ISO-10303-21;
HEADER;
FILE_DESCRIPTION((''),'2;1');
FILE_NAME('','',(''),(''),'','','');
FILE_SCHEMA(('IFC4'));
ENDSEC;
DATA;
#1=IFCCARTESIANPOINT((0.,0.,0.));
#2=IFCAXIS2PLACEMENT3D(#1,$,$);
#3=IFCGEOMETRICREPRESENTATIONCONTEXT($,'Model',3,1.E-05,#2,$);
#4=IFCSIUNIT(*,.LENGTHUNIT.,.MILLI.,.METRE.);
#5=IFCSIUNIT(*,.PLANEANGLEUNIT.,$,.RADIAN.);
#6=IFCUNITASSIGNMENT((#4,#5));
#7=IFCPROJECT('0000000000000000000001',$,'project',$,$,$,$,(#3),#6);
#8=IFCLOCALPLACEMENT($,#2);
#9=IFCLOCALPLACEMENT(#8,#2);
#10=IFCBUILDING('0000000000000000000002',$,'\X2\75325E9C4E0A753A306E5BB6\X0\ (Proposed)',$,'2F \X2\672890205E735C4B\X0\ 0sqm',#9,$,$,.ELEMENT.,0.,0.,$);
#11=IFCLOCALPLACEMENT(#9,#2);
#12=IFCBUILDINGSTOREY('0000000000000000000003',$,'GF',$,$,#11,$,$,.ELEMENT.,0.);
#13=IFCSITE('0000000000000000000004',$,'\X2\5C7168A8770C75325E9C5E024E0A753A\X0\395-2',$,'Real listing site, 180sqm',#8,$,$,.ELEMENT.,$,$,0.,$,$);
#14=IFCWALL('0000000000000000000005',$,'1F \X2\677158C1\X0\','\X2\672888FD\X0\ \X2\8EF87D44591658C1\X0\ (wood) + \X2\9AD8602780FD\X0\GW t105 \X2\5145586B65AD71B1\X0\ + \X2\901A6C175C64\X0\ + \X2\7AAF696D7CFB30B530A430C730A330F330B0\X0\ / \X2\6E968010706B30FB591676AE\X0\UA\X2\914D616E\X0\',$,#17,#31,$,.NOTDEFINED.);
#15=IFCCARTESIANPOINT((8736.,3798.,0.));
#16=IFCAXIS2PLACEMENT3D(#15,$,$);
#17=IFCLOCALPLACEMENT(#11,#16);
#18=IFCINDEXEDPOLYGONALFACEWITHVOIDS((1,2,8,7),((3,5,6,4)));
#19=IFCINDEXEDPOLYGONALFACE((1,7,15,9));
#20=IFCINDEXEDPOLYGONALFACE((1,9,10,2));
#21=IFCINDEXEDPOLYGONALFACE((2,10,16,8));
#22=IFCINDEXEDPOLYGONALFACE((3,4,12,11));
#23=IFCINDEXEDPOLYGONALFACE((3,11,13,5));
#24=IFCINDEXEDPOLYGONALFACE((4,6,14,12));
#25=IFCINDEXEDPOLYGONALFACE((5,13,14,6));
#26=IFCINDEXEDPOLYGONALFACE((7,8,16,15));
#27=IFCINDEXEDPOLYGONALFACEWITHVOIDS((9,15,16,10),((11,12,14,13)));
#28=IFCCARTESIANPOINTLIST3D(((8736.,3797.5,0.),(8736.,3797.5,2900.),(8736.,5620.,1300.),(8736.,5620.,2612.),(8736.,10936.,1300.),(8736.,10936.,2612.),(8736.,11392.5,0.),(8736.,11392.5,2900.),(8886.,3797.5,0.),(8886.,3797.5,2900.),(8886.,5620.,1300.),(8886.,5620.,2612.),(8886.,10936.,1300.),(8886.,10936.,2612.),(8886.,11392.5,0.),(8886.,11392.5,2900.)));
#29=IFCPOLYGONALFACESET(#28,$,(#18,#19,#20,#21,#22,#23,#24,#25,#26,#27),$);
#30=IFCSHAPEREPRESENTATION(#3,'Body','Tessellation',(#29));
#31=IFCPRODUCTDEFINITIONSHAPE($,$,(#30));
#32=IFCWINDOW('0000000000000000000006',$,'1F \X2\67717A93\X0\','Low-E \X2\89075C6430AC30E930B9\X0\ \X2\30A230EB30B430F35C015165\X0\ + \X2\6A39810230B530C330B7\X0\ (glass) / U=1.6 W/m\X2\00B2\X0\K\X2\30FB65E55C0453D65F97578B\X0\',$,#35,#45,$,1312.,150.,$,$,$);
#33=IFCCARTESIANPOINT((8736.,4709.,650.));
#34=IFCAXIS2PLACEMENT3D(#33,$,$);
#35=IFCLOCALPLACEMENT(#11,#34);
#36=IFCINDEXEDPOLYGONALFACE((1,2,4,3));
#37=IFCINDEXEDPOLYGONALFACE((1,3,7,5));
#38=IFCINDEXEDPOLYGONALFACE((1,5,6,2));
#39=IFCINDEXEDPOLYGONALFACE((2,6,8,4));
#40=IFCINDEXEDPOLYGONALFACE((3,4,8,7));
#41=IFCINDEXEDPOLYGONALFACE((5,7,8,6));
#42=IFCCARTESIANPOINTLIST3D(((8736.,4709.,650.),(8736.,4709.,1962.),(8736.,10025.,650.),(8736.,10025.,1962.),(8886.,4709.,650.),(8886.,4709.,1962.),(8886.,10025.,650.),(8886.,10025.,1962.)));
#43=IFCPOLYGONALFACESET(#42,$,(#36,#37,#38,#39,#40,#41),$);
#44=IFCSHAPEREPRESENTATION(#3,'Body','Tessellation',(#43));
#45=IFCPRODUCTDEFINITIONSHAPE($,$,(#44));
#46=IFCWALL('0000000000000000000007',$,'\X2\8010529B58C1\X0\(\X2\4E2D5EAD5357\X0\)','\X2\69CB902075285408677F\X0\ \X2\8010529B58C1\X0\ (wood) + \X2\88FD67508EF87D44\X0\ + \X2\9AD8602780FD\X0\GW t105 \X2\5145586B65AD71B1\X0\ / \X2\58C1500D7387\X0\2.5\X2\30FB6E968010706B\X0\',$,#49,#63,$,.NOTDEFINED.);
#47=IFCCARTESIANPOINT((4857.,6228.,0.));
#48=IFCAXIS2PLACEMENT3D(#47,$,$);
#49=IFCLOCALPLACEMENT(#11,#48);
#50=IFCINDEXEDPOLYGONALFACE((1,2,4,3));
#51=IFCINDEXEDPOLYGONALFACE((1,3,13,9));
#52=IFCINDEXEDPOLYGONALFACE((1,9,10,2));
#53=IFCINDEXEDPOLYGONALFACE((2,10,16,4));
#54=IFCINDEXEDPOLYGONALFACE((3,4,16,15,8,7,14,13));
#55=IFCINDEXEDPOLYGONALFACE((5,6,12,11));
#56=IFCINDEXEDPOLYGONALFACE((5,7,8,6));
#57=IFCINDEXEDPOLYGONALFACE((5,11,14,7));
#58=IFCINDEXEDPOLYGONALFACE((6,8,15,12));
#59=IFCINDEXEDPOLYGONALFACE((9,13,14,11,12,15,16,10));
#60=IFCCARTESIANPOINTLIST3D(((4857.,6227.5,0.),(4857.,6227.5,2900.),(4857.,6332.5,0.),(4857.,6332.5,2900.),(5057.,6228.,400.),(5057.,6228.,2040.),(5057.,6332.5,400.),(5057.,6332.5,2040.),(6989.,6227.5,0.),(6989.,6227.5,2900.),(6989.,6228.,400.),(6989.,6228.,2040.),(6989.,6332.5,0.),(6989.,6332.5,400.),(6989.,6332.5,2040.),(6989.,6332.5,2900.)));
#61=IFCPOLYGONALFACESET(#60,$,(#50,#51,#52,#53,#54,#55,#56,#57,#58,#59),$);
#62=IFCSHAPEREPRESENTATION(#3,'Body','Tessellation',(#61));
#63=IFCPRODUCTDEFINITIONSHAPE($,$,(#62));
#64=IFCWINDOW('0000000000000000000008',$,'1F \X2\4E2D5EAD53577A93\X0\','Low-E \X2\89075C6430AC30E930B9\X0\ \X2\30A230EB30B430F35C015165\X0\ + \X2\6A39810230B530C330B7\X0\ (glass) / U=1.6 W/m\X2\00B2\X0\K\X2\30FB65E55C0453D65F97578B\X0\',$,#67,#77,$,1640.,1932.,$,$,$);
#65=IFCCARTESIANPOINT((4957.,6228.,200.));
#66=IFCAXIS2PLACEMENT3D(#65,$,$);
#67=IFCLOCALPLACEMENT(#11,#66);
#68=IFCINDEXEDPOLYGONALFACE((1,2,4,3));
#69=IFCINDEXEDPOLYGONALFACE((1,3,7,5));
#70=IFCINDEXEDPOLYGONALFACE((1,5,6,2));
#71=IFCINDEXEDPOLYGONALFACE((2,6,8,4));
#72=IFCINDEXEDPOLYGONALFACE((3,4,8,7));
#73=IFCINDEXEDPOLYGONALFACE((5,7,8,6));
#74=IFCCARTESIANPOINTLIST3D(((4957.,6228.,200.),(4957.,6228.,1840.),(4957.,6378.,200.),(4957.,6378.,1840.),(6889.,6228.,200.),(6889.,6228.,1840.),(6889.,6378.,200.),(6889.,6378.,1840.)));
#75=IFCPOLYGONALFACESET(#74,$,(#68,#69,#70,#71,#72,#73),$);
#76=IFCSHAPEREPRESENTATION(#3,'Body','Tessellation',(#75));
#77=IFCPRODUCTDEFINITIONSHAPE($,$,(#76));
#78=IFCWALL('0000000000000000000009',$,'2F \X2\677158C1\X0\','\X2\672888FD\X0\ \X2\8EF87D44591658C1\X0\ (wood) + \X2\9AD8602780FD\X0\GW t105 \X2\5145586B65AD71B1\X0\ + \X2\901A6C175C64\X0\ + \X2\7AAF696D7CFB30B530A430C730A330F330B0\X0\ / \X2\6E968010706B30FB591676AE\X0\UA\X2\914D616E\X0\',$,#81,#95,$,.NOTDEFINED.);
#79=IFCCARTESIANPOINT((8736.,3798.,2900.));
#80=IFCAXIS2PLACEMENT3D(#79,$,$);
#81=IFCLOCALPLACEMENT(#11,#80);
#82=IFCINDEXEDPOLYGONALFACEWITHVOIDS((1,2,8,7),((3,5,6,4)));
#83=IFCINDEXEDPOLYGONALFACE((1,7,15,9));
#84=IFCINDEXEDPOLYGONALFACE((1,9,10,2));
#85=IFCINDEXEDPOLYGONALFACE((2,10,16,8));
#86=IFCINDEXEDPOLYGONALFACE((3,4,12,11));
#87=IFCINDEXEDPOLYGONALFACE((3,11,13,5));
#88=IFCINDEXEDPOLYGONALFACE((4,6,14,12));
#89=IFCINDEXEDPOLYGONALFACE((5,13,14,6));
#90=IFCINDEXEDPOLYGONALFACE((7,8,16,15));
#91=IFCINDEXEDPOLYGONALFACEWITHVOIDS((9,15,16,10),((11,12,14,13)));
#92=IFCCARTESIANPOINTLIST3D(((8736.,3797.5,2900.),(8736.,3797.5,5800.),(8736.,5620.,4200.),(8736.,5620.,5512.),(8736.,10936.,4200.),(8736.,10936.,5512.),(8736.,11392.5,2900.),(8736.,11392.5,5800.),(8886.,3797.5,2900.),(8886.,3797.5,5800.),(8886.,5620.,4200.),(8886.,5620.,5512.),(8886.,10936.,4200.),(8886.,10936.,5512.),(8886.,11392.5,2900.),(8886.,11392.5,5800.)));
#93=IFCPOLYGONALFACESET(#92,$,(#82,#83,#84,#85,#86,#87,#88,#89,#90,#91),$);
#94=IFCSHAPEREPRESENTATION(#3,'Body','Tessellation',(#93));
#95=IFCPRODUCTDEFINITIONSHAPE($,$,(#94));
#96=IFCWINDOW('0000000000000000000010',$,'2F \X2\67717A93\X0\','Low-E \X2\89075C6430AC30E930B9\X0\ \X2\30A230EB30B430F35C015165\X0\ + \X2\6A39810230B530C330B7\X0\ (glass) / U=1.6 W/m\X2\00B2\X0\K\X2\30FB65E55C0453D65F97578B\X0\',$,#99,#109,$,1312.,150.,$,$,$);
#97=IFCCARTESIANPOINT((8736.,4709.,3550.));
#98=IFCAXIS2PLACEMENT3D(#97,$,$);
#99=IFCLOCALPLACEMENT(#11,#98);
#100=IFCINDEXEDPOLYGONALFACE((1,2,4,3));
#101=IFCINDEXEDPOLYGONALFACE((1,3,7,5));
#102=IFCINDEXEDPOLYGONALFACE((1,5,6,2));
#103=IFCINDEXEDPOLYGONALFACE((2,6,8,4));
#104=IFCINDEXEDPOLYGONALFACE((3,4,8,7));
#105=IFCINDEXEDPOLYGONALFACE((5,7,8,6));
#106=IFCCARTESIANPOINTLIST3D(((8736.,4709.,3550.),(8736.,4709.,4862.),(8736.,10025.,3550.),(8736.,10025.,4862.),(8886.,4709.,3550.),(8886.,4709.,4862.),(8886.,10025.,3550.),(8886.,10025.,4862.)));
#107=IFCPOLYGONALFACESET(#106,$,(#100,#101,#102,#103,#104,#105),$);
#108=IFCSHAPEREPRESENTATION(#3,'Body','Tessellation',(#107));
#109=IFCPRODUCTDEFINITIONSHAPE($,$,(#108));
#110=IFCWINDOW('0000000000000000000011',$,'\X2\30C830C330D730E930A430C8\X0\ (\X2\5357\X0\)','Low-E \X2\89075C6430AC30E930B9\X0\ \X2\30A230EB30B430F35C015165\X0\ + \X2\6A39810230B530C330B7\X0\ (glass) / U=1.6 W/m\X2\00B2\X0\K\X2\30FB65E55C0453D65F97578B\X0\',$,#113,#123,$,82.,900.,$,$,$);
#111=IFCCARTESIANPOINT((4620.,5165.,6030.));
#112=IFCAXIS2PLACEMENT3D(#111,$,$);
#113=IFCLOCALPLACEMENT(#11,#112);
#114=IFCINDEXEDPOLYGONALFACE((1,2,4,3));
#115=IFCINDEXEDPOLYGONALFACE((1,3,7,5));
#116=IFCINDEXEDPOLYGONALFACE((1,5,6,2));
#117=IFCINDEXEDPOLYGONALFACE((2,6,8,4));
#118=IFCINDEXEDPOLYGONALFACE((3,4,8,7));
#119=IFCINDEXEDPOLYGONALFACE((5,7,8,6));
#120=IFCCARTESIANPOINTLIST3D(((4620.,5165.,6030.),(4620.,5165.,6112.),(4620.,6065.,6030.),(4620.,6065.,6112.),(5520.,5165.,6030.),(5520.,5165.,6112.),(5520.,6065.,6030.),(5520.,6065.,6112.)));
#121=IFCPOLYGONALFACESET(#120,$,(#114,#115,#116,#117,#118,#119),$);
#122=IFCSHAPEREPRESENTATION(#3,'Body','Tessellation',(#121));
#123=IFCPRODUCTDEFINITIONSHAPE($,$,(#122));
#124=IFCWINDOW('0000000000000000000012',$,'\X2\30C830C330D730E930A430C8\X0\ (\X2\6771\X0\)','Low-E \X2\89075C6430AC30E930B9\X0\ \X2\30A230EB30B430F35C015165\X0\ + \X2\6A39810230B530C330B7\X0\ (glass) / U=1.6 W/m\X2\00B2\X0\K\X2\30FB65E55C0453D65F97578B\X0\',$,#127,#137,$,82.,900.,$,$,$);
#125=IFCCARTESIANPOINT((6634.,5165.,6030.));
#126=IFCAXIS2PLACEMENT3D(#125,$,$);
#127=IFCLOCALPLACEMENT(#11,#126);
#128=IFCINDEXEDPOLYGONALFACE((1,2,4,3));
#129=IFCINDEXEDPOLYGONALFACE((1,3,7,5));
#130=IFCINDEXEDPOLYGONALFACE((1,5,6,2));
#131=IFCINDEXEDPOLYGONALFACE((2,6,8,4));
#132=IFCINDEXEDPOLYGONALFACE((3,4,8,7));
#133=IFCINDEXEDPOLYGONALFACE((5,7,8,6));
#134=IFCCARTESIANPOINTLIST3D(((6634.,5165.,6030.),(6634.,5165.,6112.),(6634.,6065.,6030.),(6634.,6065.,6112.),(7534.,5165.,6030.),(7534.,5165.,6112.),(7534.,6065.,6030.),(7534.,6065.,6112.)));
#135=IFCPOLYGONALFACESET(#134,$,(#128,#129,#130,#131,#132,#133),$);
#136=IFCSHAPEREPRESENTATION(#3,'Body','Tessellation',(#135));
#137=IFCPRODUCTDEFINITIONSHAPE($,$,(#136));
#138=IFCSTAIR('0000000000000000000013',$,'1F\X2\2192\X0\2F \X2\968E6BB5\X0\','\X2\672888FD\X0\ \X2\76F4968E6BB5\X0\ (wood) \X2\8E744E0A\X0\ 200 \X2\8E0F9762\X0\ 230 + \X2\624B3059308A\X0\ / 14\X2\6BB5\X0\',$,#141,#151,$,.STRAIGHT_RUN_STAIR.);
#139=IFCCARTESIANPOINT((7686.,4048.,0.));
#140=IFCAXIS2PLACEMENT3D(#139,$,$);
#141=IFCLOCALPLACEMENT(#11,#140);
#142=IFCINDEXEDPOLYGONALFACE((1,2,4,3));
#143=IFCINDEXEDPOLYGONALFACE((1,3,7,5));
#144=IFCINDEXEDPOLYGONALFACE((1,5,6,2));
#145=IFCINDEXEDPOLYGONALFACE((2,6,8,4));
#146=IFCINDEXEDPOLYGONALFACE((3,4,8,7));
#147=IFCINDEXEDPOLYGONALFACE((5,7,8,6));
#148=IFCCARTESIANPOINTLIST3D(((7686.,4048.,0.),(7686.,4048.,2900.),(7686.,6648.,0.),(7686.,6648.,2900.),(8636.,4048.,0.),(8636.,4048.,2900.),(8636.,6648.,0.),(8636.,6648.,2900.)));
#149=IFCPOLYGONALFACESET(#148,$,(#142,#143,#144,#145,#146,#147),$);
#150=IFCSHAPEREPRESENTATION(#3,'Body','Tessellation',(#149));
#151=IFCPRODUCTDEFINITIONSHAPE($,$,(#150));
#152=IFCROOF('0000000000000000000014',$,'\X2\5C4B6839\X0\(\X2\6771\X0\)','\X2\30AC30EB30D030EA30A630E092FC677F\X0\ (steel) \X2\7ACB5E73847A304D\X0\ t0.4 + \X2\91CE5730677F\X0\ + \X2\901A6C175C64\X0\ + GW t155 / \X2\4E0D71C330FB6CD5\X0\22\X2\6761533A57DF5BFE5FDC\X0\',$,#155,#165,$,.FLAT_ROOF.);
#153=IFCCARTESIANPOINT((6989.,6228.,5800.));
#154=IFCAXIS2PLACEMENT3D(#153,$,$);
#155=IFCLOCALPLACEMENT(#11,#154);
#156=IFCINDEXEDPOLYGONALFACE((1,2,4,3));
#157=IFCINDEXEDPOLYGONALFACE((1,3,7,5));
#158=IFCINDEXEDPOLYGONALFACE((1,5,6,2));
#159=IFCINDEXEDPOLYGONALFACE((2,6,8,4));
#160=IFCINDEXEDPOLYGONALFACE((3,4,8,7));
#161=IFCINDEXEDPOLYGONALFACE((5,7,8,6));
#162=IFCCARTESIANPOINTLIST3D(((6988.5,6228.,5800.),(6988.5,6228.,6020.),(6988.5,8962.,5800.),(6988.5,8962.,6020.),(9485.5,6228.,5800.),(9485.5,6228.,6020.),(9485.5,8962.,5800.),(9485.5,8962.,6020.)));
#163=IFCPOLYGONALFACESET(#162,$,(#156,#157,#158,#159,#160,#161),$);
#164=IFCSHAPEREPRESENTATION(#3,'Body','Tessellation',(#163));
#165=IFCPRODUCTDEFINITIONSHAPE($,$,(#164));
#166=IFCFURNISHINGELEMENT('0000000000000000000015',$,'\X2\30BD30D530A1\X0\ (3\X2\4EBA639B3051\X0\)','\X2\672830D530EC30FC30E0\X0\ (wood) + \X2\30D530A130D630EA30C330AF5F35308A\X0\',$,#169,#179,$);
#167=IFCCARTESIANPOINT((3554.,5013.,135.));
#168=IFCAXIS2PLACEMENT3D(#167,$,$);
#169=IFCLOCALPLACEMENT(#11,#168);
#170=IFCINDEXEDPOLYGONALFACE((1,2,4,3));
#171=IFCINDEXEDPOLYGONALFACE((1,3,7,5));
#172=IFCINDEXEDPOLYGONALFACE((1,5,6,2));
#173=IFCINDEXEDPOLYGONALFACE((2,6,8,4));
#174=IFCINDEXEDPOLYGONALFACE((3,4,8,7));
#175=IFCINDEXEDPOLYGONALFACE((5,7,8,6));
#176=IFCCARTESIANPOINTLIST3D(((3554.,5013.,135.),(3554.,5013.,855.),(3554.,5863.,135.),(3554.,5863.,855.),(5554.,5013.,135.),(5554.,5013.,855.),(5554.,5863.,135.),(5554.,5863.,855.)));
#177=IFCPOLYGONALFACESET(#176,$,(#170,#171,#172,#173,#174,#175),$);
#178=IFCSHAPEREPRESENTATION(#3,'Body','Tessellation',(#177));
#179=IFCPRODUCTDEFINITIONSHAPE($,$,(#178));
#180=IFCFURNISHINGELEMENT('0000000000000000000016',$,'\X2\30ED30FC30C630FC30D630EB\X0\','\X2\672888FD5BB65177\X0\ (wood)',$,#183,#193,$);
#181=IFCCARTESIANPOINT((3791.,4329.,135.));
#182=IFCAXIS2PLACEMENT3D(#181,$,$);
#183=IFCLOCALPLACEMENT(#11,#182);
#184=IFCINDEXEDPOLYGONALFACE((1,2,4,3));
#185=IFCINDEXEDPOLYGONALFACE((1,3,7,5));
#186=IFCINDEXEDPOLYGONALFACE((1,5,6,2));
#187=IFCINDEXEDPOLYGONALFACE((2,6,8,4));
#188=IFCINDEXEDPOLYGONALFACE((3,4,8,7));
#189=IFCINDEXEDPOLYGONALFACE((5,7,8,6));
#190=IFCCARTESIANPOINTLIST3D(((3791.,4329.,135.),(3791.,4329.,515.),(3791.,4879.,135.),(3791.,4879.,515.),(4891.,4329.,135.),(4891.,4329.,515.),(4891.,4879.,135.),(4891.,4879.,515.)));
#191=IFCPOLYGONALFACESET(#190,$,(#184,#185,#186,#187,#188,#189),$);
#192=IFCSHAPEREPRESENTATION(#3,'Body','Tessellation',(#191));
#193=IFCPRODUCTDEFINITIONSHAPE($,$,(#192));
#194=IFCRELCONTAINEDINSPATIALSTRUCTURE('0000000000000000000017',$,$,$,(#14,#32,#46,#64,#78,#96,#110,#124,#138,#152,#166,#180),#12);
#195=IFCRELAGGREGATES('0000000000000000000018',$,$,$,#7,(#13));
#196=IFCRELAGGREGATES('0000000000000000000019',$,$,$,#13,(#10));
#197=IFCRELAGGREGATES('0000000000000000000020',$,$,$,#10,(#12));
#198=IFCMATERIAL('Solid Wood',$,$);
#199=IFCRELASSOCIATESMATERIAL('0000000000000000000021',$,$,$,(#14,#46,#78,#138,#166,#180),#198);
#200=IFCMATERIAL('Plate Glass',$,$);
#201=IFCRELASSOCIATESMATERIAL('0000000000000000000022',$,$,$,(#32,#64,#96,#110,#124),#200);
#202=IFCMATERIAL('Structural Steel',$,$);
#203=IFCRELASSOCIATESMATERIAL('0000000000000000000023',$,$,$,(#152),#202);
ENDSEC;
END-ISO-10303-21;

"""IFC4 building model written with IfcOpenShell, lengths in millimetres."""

from ifc_helpers import new_model, si_unit, frame, frame_2d, origin, place, context, project, spatial, rectangle, extrude, material, element, fill, save


model = new_model("IFC4")

# Units and contexts
model_context = context("Model", 3, precision=1e-05, world=origin())
ifc_project = project(units=[si_unit("LENGTHUNIT", "METRE", prefix="MILLI"), si_unit("PLANEANGLEUNIT", "RADIAN")], contexts=[model_context])

# Site, building, storey
site_placement = place(None, origin())
site = spatial("IfcSite", under=ifc_project, at=site_placement, Name="山梨県甲府市上町395-2", ObjectType="Real listing site, 180sqm", CompositionType="ELEMENT", RefElevation=0.0)
building_placement = place(site_placement, origin())
building = spatial("IfcBuilding", under=site, at=building_placement, Name="甲府上町の家 (Proposed)", ObjectType="2F 木造平屋 0sqm", CompositionType="ELEMENT", ElevationOfRefHeight=0.0, ElevationOfTerrain=0.0)
storey_placement = place(building_placement, origin())
storey = spatial("IfcBuildingStorey", under=building, at=storey_placement, Name="GF", CompositionType="ELEMENT", Elevation=0.0)

# Shared definitions
ifc_material_1 = material(Name="Solid Wood")

# Walls, openings, windows
wall_1_placement = place(storey_placement, frame((8736.0, 3798.0, 0.0)))
wall_1 = element("IfcWall", 1, at=wall_1_placement, inside=storey, material=ifc_material_1, Name="1F 東壁", Description="木製 軸組外壁 (wood) + 高性能GW t105 充填断熱 + 通気層 + 窯業系サイディング / 準耐火・外皮UA配慮", PredefinedType="NOTDEFINED", context=model_context, shape_type="SweptSolid", body=[
    extrude(rectangle(XDim=150.0, YDim=7595.0, at=frame_2d((75.0, 3797.0))), frame((8736.0, 3798.0, 0.0)), (0.0, 0.0, 1.0), 2900.0),
])
opening_1_placement = place(storey_placement, frame((8736.0, 4709.0, 650.0)))
opening_1 = element("IfcOpeningElement", 2, at=opening_1_placement, cuts=wall_1, PredefinedType="NOTDEFINED", context=model_context, shape_type="SweptSolid", body=[
    extrude(rectangle(XDim=150.0, YDim=5316.0, at=frame_2d((75.0, 2658.0))), frame((8736.0, 4709.0, 650.0)), (0.0, 0.0, 1.0), 1312.0),
])
ifc_material_2 = material(Name="Plate Glass")
window_1_placement = place(storey_placement, frame((8736.0, 4709.0, 650.0)))
window_1 = element("IfcWindow", 3, at=window_1_placement, inside=storey, material=ifc_material_2, Name="1F 東窓", Description="Low-E 複層ガラス アルゴン封入 + 樹脂サッシ (glass) / U=1.6 W/m²K・日射取得型", OverallHeight=1312.0, OverallWidth=150.0, context=model_context, shape_type="SweptSolid", body=[
    extrude(rectangle(XDim=150.0, YDim=5316.0, at=frame_2d((75.0, 2658.0))), frame((8736.0, 4709.0, 650.0)), (0.0, 0.0, 1.0), 1312.0),
])
fill(opening_1, window_1)
wall_2_placement = place(storey_placement, frame((4857.0, 6228.0, 0.0)))
wall_2 = element("IfcWall", 4, at=wall_2_placement, inside=storey, material=ifc_material_1, Name="耐力壁(中庭南)", Description="構造用合板 耐力壁 (wood) + 製材軸組 + 高性能GW t105 充填断熱 / 壁倍率2.5・準耐火", PredefinedType="NOTDEFINED", context=model_context, shape_type="SweptSolid", body=[
    extrude(rectangle(XDim=2132.0, YDim=105.0, at=frame_2d((1066.0, 52.0))), frame((4857.0, 6228.0, 0.0)), (0.0, 0.0, 1.0), 2900.0),
])
opening_2_placement = place(storey_placement, frame((4957.0, 6228.0, 200.0)))
opening_2 = element("IfcOpeningElement", 5, at=opening_2_placement, cuts=wall_2, PredefinedType="NOTDEFINED", context=model_context, shape_type="SweptSolid", body=[
    extrude(rectangle(XDim=1932.0, YDim=150.0, at=frame_2d((966.0, 75.0))), frame((4957.0, 6228.0, 200.0)), (0.0, 0.0, 1.0), 1640.0),
])
window_2_placement = place(storey_placement, frame((4957.0, 6228.0, 200.0)))
window_2 = element("IfcWindow", 6, at=window_2_placement, inside=storey, material=ifc_material_2, Name="1F 中庭南窓", Description="Low-E 複層ガラス アルゴン封入 + 樹脂サッシ (glass) / U=1.6 W/m²K・日射取得型", OverallHeight=1640.0, OverallWidth=1932.0, context=model_context, shape_type="SweptSolid", body=[
    extrude(rectangle(XDim=1932.0, YDim=150.0, at=frame_2d((966.0, 75.0))), frame((4957.0, 6228.0, 200.0)), (0.0, 0.0, 1.0), 1640.0),
])
fill(opening_2, window_2)

# Wall, opening, window
wall_3_placement = place(storey_placement, frame((8736.0, 3798.0, 2900.0)))
wall_3 = element("IfcWall", 7, at=wall_3_placement, inside=storey, material=ifc_material_1, Name="2F 東壁", Description="木製 軸組外壁 (wood) + 高性能GW t105 充填断熱 + 通気層 + 窯業系サイディング / 準耐火・外皮UA配慮", PredefinedType="NOTDEFINED", context=model_context, shape_type="SweptSolid", body=[
    extrude(rectangle(XDim=150.0, YDim=7595.0, at=frame_2d((75.0, 3797.0))), frame((8736.0, 3798.0, 2900.0)), (0.0, 0.0, 1.0), 2900.0),
])
opening_3_placement = place(storey_placement, frame((8736.0, 4709.0, 3550.0)))
opening_3 = element("IfcOpeningElement", 8, at=opening_3_placement, cuts=wall_3, PredefinedType="NOTDEFINED", context=model_context, shape_type="SweptSolid", body=[
    extrude(rectangle(XDim=150.0, YDim=5316.0, at=frame_2d((75.0, 2658.0))), frame((8736.0, 4709.0, 3550.0)), (0.0, 0.0, 1.0), 1312.0),
])
window_3_placement = place(storey_placement, frame((8736.0, 4709.0, 3550.0)))
window_3 = element("IfcWindow", 9, at=window_3_placement, inside=storey, material=ifc_material_2, Name="2F 東窓", Description="Low-E 複層ガラス アルゴン封入 + 樹脂サッシ (glass) / U=1.6 W/m²K・日射取得型", OverallHeight=1312.0, OverallWidth=150.0, context=model_context, shape_type="SweptSolid", body=[
    extrude(rectangle(XDim=150.0, YDim=5316.0, at=frame_2d((75.0, 2658.0))), frame((8736.0, 4709.0, 3550.0)), (0.0, 0.0, 1.0), 1312.0),
])
fill(opening_3, window_3)

# Windows
window_4_placement = place(storey_placement, frame((4620.0, 5165.0, 6030.0)))
element("IfcWindow", 10, at=window_4_placement, inside=storey, material=ifc_material_2, Name="トップライト (南)", Description="Low-E 複層ガラス アルゴン封入 + 樹脂サッシ (glass) / U=1.6 W/m²K・日射取得型", OverallHeight=82.0, OverallWidth=900.0, context=model_context, shape_type="SweptSolid", body=[
    extrude(rectangle(XDim=900.0, YDim=900.0, at=frame_2d((450.0, 450.0))), frame((4620.0, 5165.0, 6030.0)), (0.0, 0.0, 1.0), 82.0),
])
window_5_placement = place(storey_placement, frame((6634.0, 5165.0, 6030.0)))
element("IfcWindow", 11, at=window_5_placement, inside=storey, material=ifc_material_2, Name="トップライト (東)", Description="Low-E 複層ガラス アルゴン封入 + 樹脂サッシ (glass) / U=1.6 W/m²K・日射取得型", OverallHeight=82.0, OverallWidth=900.0, context=model_context, shape_type="SweptSolid", body=[
    extrude(rectangle(XDim=900.0, YDim=900.0, at=frame_2d((450.0, 450.0))), frame((6634.0, 5165.0, 6030.0)), (0.0, 0.0, 1.0), 82.0),
])

# Stair
stair_placement = place(storey_placement, frame((7686.0, 4048.0, 0.0)))
element("IfcStair", 12, at=stair_placement, inside=storey, material=ifc_material_1, Name="1F→2F 階段", Description="木製 直階段 (wood) 蹴上 200 踏面 230 + 手すり / 14段", PredefinedType="STRAIGHT_RUN_STAIR", context=model_context, shape_type="SweptSolid", body=[
    extrude(rectangle(XDim=950.0, YDim=2600.0, at=frame_2d((475.0, 1300.0))), frame((7686.0, 4048.0, 0.0)), (0.0, 0.0, 1.0), 2900.0),
])

# Roof
ifc_material_3 = material(Name="Structural Steel")
roof_placement = place(storey_placement, frame((6989.0, 6228.0, 5800.0)))
element("IfcRoof", 13, at=roof_placement, inside=storey, material=ifc_material_3, Name="屋根(東)", Description="ガルバリウム鋼板 (steel) 立平葺き t0.4 + 野地板 + 通気層 + GW t155 / 不燃・法22条区域対応", PredefinedType="FLAT_ROOF", context=model_context, shape_type="SweptSolid", body=[
    extrude(rectangle(XDim=2497.0, YDim=2734.0, at=frame_2d((1248.0, 1367.0))), frame((6989.0, 6228.0, 5800.0)), (0.0, 0.0, 1.0), 220.0),
])

# Furnishing elements
furnishing_1_placement = place(storey_placement, frame((3554.0, 5013.0, 135.0)))
element("IfcFurnishingElement", 14, at=furnishing_1_placement, inside=storey, material=ifc_material_1, Name="ソファ (3人掛け)", Description="木フレーム (wood) + ファブリック張り", context=model_context, shape_type="SweptSolid", body=[
    extrude(rectangle(XDim=2000.0, YDim=850.0, at=frame_2d((1000.0, 425.0))), frame((3554.0, 5013.0, 135.0)), (0.0, 0.0, 1.0), 720.0),
])
furnishing_2_placement = place(storey_placement, frame((3791.0, 4329.0, 135.0)))
element("IfcFurnishingElement", 15, at=furnishing_2_placement, inside=storey, material=ifc_material_1, Name="ローテーブル", Description="木製家具 (wood)", context=model_context, shape_type="SweptSolid", body=[
    extrude(rectangle(XDim=1100.0, YDim=550.0, at=frame_2d((550.0, 275.0))), frame((3791.0, 4329.0, 135.0)), (0.0, 0.0, 1.0), 380.0),
])

save(model, "model.ifc")
